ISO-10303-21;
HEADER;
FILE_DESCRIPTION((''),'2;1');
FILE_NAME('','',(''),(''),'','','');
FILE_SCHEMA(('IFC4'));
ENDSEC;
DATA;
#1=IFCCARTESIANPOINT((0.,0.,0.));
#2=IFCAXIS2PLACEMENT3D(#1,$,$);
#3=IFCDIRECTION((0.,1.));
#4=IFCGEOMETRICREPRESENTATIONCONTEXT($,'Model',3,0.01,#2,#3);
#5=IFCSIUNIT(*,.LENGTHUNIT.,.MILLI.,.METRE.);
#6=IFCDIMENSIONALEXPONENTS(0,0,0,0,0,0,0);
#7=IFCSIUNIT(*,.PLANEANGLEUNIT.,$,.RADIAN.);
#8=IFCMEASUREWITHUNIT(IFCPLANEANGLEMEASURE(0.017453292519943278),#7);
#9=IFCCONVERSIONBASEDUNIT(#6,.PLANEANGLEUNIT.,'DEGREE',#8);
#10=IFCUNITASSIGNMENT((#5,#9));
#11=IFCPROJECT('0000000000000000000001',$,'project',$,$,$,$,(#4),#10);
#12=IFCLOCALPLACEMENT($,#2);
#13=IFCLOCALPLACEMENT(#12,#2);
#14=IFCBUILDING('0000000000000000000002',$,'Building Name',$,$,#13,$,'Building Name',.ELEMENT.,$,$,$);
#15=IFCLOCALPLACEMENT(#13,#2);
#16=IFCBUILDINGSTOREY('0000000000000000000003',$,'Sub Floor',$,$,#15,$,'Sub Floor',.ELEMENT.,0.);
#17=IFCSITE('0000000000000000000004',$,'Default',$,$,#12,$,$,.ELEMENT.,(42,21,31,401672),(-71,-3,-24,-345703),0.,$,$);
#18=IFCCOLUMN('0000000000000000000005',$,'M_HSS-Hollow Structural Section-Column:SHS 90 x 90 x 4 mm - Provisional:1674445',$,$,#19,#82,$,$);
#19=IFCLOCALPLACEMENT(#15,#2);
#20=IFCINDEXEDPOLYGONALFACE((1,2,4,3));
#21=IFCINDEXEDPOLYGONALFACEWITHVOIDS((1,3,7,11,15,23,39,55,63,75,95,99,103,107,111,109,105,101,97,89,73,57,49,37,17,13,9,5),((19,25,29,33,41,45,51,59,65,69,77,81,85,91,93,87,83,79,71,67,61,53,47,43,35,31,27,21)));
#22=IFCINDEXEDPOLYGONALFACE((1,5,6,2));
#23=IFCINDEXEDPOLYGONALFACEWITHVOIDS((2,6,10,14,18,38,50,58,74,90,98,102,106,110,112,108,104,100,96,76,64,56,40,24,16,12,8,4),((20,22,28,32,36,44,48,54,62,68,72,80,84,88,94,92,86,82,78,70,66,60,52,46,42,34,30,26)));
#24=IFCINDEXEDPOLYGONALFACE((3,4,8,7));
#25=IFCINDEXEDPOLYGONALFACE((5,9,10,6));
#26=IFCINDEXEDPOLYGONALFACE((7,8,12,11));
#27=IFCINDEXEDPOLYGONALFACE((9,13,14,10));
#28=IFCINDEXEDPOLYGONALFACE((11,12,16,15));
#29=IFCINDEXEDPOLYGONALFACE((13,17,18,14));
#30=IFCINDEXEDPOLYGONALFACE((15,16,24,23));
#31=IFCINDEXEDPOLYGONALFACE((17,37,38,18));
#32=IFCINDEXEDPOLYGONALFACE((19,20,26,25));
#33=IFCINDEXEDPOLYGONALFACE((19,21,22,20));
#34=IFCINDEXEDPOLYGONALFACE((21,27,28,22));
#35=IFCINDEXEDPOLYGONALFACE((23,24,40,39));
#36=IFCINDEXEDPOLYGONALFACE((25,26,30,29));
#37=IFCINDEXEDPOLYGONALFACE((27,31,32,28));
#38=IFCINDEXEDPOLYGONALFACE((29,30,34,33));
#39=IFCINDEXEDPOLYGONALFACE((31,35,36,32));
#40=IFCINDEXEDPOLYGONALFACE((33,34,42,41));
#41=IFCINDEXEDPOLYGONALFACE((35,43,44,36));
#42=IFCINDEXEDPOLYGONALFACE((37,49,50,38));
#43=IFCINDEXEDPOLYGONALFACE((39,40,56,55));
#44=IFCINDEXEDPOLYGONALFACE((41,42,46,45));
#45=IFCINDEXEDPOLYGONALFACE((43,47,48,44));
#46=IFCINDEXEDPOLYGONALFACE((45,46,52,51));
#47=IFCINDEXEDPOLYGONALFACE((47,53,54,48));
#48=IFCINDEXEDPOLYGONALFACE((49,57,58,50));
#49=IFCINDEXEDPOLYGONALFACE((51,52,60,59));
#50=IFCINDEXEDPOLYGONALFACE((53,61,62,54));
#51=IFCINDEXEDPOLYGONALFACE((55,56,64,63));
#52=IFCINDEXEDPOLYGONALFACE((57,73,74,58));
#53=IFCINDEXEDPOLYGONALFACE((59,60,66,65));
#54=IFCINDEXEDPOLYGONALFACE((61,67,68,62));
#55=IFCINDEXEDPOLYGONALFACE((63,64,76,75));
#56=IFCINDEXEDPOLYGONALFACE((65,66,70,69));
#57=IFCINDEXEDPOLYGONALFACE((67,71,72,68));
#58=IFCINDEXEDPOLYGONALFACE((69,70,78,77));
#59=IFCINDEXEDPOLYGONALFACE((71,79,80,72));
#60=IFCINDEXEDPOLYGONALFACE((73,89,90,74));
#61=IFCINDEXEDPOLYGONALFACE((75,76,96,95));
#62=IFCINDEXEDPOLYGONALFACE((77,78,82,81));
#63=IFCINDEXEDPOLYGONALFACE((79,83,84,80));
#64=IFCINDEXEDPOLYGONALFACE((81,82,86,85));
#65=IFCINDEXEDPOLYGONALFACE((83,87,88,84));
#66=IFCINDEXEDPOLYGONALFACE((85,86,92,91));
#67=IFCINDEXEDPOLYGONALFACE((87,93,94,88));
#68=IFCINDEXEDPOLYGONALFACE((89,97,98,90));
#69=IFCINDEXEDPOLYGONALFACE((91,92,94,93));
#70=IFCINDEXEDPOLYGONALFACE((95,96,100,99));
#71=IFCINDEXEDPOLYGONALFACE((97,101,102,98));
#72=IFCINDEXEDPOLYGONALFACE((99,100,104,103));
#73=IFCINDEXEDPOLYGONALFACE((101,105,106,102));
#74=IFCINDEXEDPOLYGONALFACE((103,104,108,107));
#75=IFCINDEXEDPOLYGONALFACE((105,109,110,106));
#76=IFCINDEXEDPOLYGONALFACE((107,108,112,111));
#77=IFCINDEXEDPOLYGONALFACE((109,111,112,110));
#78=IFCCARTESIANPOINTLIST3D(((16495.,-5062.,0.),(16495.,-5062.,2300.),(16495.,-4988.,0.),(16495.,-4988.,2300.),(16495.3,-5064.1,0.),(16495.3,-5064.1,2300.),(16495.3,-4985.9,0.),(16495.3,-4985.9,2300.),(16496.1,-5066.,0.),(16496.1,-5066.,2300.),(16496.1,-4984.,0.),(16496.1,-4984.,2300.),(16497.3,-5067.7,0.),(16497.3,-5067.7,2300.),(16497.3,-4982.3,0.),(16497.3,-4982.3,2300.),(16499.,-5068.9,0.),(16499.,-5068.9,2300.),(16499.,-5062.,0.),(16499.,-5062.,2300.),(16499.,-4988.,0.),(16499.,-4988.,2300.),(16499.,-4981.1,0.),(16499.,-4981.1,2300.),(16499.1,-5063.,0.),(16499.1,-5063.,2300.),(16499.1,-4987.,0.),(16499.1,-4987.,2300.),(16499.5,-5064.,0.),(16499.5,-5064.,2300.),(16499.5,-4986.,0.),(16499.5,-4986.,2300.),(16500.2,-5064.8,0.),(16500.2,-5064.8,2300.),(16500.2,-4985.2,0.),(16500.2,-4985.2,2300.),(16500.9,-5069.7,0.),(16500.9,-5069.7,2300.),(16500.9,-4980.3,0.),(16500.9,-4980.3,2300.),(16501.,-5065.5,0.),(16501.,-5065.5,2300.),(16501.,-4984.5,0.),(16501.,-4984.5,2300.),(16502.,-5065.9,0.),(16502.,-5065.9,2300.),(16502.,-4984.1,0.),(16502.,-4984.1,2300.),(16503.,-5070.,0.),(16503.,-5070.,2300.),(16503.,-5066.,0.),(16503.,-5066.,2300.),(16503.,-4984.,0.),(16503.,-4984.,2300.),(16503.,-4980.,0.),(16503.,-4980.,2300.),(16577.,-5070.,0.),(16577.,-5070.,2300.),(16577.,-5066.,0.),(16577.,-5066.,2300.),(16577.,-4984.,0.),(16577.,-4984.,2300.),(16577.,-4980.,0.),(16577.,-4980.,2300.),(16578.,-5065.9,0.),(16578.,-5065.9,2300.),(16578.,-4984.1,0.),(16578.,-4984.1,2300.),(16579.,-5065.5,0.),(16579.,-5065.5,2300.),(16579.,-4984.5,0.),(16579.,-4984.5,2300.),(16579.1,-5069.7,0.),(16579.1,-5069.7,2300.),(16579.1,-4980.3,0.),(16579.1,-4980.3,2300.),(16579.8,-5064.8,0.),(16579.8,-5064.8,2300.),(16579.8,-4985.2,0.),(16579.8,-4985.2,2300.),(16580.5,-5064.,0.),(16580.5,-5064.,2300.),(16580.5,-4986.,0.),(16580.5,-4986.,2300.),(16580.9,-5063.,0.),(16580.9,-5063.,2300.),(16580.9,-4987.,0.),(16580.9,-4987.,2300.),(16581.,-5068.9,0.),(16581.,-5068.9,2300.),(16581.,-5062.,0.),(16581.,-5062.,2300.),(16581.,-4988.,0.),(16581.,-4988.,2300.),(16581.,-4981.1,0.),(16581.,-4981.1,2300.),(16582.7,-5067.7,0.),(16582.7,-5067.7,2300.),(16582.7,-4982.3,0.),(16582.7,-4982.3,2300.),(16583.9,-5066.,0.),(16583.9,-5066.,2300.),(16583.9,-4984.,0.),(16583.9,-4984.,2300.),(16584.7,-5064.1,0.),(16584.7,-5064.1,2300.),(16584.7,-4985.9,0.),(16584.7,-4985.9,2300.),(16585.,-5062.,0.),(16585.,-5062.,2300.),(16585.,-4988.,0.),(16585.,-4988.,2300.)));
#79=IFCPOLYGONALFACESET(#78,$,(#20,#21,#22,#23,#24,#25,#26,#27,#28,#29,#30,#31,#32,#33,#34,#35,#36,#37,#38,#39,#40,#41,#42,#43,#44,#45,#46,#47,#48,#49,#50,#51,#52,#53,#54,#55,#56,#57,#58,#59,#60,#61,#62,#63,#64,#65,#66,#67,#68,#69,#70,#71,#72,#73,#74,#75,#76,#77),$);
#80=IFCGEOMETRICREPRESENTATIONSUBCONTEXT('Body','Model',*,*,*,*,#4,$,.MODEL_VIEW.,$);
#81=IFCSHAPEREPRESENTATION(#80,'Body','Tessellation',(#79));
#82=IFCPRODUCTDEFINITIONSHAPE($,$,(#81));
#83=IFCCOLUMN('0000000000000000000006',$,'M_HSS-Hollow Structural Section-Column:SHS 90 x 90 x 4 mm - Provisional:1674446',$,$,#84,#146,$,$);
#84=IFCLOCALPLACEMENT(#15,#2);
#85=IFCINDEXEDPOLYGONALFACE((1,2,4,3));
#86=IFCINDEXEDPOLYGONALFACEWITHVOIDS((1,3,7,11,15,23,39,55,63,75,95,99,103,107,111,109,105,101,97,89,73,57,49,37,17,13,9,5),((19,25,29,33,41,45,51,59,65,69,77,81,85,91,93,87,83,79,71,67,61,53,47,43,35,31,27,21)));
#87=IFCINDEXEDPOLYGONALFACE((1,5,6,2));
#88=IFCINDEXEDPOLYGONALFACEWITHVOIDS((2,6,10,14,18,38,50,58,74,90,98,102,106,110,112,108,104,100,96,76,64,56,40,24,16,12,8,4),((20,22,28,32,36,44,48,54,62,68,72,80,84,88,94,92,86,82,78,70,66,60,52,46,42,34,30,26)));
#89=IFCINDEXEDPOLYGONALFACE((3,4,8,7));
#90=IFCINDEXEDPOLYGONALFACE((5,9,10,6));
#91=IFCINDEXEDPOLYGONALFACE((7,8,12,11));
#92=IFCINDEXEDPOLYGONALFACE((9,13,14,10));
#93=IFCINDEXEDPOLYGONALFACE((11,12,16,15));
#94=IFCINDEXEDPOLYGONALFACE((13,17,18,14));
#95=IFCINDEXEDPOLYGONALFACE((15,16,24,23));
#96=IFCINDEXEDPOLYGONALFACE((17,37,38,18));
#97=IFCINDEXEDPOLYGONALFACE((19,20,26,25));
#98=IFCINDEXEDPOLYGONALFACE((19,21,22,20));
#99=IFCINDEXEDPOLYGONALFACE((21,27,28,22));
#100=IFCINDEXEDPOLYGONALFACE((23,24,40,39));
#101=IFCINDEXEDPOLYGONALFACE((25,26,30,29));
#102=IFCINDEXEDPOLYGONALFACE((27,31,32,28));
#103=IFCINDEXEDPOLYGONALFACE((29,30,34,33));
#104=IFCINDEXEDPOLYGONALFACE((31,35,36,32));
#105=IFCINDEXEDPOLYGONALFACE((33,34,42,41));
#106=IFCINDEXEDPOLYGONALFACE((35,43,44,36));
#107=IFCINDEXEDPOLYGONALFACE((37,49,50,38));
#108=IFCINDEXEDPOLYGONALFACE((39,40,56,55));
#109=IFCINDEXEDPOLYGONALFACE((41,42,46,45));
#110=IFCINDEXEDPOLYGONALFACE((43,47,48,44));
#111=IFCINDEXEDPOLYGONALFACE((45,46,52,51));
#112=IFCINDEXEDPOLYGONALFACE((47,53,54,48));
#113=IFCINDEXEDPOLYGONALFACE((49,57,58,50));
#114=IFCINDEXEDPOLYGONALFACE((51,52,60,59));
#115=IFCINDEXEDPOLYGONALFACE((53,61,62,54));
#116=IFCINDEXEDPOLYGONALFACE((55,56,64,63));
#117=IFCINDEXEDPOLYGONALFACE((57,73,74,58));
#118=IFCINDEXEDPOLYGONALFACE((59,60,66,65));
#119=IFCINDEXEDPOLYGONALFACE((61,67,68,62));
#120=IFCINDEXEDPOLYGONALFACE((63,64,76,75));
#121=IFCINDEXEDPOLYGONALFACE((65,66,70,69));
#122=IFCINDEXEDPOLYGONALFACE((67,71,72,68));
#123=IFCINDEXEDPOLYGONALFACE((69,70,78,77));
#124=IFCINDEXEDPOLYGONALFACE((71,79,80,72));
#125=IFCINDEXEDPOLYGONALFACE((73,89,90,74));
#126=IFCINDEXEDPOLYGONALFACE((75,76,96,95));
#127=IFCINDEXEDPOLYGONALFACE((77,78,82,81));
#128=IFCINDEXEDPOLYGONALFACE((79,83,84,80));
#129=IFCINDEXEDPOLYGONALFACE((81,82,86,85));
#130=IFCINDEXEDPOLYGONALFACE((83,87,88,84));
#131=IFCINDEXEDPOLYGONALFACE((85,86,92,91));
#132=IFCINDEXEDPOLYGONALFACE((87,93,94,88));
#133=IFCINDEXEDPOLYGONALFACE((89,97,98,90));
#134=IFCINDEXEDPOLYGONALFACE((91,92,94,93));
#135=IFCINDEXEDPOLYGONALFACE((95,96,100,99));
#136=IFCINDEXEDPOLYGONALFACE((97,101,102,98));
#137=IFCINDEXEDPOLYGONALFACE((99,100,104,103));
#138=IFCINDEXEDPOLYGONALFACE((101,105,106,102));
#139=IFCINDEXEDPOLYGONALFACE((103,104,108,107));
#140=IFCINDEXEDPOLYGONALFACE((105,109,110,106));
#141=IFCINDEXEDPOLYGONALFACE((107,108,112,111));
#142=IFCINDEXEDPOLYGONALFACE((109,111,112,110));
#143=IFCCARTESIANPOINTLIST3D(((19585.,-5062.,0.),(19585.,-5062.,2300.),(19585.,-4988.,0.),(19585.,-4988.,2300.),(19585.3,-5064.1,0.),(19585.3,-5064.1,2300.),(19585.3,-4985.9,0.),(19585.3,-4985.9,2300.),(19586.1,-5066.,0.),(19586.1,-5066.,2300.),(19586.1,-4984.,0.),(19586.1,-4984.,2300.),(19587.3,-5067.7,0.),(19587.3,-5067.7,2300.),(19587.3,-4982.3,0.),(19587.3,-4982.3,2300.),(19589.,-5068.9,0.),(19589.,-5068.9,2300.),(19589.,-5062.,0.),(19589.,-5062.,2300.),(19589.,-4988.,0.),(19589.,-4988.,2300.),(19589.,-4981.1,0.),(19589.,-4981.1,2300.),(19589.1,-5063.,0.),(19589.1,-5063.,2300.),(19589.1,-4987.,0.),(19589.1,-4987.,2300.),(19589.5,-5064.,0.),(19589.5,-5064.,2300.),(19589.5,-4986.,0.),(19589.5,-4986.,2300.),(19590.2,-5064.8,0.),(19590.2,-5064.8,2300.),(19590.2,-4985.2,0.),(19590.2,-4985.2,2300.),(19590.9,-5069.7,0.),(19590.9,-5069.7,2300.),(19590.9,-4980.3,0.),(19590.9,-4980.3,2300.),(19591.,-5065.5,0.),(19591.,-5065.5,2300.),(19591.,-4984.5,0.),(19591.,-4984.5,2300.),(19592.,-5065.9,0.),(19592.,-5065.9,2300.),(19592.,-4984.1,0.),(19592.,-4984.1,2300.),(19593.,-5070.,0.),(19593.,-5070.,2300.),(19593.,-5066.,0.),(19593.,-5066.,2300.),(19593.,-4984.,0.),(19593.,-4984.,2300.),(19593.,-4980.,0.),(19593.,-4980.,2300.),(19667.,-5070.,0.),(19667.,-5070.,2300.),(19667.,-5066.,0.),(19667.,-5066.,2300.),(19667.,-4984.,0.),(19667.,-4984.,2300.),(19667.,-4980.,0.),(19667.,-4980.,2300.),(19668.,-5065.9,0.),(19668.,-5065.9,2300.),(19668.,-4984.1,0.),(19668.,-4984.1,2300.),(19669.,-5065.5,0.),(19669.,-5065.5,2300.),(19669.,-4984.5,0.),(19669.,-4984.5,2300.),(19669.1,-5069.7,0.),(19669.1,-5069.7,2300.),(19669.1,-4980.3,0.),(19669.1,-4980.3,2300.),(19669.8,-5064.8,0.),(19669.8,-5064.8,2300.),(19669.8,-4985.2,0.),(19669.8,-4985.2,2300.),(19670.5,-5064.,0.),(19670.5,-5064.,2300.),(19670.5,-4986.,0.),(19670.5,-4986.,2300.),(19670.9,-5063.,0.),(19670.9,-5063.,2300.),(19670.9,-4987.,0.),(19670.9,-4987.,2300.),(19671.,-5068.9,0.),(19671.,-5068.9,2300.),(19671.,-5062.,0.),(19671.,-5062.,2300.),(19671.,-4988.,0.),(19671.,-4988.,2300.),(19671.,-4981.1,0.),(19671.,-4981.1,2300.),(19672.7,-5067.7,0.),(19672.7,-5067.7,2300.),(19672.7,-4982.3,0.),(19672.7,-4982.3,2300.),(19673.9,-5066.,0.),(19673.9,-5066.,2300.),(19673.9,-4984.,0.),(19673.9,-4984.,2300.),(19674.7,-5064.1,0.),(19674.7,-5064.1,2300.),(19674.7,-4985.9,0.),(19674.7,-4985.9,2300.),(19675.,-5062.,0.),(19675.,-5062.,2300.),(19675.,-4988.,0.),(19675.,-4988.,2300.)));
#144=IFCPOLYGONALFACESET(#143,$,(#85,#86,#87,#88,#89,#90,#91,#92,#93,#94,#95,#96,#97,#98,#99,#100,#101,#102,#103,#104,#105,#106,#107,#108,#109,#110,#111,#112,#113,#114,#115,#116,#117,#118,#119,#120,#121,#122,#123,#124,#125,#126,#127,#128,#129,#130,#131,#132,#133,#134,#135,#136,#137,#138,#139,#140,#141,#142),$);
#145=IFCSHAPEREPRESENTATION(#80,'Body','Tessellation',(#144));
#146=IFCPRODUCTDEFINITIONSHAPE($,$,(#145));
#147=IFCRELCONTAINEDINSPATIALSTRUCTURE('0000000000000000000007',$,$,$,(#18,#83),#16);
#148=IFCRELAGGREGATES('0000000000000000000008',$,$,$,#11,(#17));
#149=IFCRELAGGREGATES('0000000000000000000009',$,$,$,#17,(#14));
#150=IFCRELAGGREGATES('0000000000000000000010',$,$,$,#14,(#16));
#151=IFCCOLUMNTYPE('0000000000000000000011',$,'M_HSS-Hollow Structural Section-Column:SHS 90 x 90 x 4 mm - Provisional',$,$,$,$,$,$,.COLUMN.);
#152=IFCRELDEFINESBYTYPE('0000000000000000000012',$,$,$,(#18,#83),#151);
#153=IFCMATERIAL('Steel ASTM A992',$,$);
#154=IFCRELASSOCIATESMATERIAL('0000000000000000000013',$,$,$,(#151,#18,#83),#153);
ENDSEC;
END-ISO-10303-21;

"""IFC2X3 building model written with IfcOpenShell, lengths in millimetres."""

from ifc_helpers import new_model, entity, si_unit, converted_unit, direction, frame, frame_2d, origin, place, context, subcontext, project, spatial, polyline, circle_curve, parameter, trimmed, segment, composite_curve, outline, extrude, source, transform, mapped, material, type_object, type_shapes, element, save


model = new_model("IFC2X3")

# Units and contexts
model_context = context("Model", 3, precision=0.01, world=origin(), true_north=direction((0.0, 1.0)))
body_context = subcontext(model_context, "Body", "Model", "MODEL_VIEW")
ifc_project = project(units=[si_unit("LENGTHUNIT", "METRE", prefix="MILLI"), converted_unit("PLANEANGLEUNIT", "DEGREE", entity("IfcPlaneAngleMeasure", 0.017453292519943278), si_unit("PLANEANGLEUNIT", "RADIAN"), dimensions=[0, 0, 0, 0, 0, 0, 0])], contexts=[model_context])

# Site, building, storey
site_placement = place(None, origin())
site = spatial("IfcSite", under=ifc_project, at=site_placement, Name="Default", CompositionType="ELEMENT", RefLatitude=(42, 21, 31, 401672), RefLongitude=(-71, -3, -24, -345703), RefElevation=0.0)
building_placement = place(site_placement, origin())
building = spatial("IfcBuilding", under=site, at=building_placement, Name="Building Name", LongName="Building Name", CompositionType="ELEMENT")
storey_placement = place(building_placement, origin())
storey = spatial("IfcBuildingStorey", under=building, at=storey_placement, Name="Sub Floor", LongName="Sub Floor", CompositionType="ELEMENT", Elevation=0.0)

# Columns
ifc_material_1 = material(Name="Steel ASTM A992")
column_type = type_object("IfcColumnType", Name="M_HSS-Hollow Structural Section-Column:SHS 90 x 90 x 4 mm - Provisional", PredefinedType="COLUMN", material=ifc_material_1)
shared_shape_1 = source(origin(), body_context, "Body", "SweptSolid", [
    extrude(outline(composite_curve([segment(polyline([(-37.0, -45.0), (37.0, -45.0)]), True, "CONTINUOUS"), segment(trimmed(circle_curve(frame_2d((37.0, -37.0), x_axis=(-1.0, 0.0)), 8.0), [parameter(90.0)], [parameter(180.0)], True, "PARAMETER"), True, "CONTINUOUS"), segment(polyline([(45.0, -37.0), (45.0, 37.0)]), True, "CONTINUOUS"), segment(trimmed(circle_curve(frame_2d((37.0, 37.0), x_axis=(-1.0, 0.0)), 8.0), [parameter(180.0)], [parameter(270.0)], True, "PARAMETER"), True, "CONTINUOUS"), segment(polyline([(37.0, 45.0), (-37.0, 45.0)]), True, "CONTINUOUS"), segment(trimmed(circle_curve(frame_2d((-37.0, 37.0), x_axis=(-1.0, 0.0)), 8.0), [parameter(270.0)], [parameter(360.0)], True, "PARAMETER"), True, "CONTINUOUS"), segment(polyline([(-45.0, 37.0), (-45.0, -37.0)]), True, "CONTINUOUS"), segment(trimmed(circle_curve(frame_2d((-37.0, -37.0), x_axis=(-1.0, 0.0)), 8.0), [parameter(360.0)], [parameter(90.0)], True, "PARAMETER"), True, "CONTINUOUS")], self_intersect=False), holes=[composite_curve([segment(trimmed(circle_curve(frame_2d((-37.0, -37.0), x_axis=(-1.0, 0.0)), 4.0), [parameter(0.0)], [parameter(90.0)], True, "PARAMETER"), False, "CONTINUOUS"), segment(polyline([(-41.0, -37.0), (-41.0, 37.0)]), True, "CONTINUOUS"), segment(trimmed(circle_curve(frame_2d((-37.0, 37.0), x_axis=(-1.0, 0.0)), 4.0), [parameter(270.0)], [parameter(0.0)], True, "PARAMETER"), False, "CONTINUOUS"), segment(polyline([(-37.0, 41.0), (37.0, 41.0)]), True, "CONTINUOUS"), segment(trimmed(circle_curve(frame_2d((37.0, 37.0), x_axis=(-1.0, 0.0)), 4.0), [parameter(180.0)], [parameter(270.0)], True, "PARAMETER"), False, "CONTINUOUS"), segment(polyline([(41.0, 37.0), (41.0, -37.0)]), True, "CONTINUOUS"), segment(trimmed(circle_curve(frame_2d((37.0, -37.0), x_axis=(-1.0, 0.0)), 4.0), [parameter(90.0)], [parameter(180.0)], True, "PARAMETER"), False, "CONTINUOUS"), segment(polyline([(37.0, -41.0), (-37.0, -41.0)]), True, "CONTINUOUS")], self_intersect=False)]), frame((0.0, 0.0, 0.0), z_axis=(0.0, 0.0, 1.0), x_axis=(-1.0, 0.0, 0.0)), (0.0, 0.0, 1.0), 2300.0),
])
type_shapes(column_type, [shared_shape_1])
for number, where, name in (
    (1, (16540.0, -5025.0, 0.0), "M_HSS-Hollow Structural Section-Column:SHS 90 x 90 x 4 mm - Provisional:1674445"),
    (2, (19630.0, -5025.0, 0.0), "M_HSS-Hollow Structural Section-Column:SHS 90 x 90 x 4 mm - Provisional:1674446"),
):
    element("IfcColumn", number, at=place(storey_placement, frame(where)), inside=storey, type_object=column_type, material=ifc_material_1, Name=name, context=body_context, shape_type="MappedRepresentation", body=[
        mapped(shared_shape_1, transform((0.0, 0.0, 0.0), scale=1.0)),
    ])

save(model, "model.ifc")
